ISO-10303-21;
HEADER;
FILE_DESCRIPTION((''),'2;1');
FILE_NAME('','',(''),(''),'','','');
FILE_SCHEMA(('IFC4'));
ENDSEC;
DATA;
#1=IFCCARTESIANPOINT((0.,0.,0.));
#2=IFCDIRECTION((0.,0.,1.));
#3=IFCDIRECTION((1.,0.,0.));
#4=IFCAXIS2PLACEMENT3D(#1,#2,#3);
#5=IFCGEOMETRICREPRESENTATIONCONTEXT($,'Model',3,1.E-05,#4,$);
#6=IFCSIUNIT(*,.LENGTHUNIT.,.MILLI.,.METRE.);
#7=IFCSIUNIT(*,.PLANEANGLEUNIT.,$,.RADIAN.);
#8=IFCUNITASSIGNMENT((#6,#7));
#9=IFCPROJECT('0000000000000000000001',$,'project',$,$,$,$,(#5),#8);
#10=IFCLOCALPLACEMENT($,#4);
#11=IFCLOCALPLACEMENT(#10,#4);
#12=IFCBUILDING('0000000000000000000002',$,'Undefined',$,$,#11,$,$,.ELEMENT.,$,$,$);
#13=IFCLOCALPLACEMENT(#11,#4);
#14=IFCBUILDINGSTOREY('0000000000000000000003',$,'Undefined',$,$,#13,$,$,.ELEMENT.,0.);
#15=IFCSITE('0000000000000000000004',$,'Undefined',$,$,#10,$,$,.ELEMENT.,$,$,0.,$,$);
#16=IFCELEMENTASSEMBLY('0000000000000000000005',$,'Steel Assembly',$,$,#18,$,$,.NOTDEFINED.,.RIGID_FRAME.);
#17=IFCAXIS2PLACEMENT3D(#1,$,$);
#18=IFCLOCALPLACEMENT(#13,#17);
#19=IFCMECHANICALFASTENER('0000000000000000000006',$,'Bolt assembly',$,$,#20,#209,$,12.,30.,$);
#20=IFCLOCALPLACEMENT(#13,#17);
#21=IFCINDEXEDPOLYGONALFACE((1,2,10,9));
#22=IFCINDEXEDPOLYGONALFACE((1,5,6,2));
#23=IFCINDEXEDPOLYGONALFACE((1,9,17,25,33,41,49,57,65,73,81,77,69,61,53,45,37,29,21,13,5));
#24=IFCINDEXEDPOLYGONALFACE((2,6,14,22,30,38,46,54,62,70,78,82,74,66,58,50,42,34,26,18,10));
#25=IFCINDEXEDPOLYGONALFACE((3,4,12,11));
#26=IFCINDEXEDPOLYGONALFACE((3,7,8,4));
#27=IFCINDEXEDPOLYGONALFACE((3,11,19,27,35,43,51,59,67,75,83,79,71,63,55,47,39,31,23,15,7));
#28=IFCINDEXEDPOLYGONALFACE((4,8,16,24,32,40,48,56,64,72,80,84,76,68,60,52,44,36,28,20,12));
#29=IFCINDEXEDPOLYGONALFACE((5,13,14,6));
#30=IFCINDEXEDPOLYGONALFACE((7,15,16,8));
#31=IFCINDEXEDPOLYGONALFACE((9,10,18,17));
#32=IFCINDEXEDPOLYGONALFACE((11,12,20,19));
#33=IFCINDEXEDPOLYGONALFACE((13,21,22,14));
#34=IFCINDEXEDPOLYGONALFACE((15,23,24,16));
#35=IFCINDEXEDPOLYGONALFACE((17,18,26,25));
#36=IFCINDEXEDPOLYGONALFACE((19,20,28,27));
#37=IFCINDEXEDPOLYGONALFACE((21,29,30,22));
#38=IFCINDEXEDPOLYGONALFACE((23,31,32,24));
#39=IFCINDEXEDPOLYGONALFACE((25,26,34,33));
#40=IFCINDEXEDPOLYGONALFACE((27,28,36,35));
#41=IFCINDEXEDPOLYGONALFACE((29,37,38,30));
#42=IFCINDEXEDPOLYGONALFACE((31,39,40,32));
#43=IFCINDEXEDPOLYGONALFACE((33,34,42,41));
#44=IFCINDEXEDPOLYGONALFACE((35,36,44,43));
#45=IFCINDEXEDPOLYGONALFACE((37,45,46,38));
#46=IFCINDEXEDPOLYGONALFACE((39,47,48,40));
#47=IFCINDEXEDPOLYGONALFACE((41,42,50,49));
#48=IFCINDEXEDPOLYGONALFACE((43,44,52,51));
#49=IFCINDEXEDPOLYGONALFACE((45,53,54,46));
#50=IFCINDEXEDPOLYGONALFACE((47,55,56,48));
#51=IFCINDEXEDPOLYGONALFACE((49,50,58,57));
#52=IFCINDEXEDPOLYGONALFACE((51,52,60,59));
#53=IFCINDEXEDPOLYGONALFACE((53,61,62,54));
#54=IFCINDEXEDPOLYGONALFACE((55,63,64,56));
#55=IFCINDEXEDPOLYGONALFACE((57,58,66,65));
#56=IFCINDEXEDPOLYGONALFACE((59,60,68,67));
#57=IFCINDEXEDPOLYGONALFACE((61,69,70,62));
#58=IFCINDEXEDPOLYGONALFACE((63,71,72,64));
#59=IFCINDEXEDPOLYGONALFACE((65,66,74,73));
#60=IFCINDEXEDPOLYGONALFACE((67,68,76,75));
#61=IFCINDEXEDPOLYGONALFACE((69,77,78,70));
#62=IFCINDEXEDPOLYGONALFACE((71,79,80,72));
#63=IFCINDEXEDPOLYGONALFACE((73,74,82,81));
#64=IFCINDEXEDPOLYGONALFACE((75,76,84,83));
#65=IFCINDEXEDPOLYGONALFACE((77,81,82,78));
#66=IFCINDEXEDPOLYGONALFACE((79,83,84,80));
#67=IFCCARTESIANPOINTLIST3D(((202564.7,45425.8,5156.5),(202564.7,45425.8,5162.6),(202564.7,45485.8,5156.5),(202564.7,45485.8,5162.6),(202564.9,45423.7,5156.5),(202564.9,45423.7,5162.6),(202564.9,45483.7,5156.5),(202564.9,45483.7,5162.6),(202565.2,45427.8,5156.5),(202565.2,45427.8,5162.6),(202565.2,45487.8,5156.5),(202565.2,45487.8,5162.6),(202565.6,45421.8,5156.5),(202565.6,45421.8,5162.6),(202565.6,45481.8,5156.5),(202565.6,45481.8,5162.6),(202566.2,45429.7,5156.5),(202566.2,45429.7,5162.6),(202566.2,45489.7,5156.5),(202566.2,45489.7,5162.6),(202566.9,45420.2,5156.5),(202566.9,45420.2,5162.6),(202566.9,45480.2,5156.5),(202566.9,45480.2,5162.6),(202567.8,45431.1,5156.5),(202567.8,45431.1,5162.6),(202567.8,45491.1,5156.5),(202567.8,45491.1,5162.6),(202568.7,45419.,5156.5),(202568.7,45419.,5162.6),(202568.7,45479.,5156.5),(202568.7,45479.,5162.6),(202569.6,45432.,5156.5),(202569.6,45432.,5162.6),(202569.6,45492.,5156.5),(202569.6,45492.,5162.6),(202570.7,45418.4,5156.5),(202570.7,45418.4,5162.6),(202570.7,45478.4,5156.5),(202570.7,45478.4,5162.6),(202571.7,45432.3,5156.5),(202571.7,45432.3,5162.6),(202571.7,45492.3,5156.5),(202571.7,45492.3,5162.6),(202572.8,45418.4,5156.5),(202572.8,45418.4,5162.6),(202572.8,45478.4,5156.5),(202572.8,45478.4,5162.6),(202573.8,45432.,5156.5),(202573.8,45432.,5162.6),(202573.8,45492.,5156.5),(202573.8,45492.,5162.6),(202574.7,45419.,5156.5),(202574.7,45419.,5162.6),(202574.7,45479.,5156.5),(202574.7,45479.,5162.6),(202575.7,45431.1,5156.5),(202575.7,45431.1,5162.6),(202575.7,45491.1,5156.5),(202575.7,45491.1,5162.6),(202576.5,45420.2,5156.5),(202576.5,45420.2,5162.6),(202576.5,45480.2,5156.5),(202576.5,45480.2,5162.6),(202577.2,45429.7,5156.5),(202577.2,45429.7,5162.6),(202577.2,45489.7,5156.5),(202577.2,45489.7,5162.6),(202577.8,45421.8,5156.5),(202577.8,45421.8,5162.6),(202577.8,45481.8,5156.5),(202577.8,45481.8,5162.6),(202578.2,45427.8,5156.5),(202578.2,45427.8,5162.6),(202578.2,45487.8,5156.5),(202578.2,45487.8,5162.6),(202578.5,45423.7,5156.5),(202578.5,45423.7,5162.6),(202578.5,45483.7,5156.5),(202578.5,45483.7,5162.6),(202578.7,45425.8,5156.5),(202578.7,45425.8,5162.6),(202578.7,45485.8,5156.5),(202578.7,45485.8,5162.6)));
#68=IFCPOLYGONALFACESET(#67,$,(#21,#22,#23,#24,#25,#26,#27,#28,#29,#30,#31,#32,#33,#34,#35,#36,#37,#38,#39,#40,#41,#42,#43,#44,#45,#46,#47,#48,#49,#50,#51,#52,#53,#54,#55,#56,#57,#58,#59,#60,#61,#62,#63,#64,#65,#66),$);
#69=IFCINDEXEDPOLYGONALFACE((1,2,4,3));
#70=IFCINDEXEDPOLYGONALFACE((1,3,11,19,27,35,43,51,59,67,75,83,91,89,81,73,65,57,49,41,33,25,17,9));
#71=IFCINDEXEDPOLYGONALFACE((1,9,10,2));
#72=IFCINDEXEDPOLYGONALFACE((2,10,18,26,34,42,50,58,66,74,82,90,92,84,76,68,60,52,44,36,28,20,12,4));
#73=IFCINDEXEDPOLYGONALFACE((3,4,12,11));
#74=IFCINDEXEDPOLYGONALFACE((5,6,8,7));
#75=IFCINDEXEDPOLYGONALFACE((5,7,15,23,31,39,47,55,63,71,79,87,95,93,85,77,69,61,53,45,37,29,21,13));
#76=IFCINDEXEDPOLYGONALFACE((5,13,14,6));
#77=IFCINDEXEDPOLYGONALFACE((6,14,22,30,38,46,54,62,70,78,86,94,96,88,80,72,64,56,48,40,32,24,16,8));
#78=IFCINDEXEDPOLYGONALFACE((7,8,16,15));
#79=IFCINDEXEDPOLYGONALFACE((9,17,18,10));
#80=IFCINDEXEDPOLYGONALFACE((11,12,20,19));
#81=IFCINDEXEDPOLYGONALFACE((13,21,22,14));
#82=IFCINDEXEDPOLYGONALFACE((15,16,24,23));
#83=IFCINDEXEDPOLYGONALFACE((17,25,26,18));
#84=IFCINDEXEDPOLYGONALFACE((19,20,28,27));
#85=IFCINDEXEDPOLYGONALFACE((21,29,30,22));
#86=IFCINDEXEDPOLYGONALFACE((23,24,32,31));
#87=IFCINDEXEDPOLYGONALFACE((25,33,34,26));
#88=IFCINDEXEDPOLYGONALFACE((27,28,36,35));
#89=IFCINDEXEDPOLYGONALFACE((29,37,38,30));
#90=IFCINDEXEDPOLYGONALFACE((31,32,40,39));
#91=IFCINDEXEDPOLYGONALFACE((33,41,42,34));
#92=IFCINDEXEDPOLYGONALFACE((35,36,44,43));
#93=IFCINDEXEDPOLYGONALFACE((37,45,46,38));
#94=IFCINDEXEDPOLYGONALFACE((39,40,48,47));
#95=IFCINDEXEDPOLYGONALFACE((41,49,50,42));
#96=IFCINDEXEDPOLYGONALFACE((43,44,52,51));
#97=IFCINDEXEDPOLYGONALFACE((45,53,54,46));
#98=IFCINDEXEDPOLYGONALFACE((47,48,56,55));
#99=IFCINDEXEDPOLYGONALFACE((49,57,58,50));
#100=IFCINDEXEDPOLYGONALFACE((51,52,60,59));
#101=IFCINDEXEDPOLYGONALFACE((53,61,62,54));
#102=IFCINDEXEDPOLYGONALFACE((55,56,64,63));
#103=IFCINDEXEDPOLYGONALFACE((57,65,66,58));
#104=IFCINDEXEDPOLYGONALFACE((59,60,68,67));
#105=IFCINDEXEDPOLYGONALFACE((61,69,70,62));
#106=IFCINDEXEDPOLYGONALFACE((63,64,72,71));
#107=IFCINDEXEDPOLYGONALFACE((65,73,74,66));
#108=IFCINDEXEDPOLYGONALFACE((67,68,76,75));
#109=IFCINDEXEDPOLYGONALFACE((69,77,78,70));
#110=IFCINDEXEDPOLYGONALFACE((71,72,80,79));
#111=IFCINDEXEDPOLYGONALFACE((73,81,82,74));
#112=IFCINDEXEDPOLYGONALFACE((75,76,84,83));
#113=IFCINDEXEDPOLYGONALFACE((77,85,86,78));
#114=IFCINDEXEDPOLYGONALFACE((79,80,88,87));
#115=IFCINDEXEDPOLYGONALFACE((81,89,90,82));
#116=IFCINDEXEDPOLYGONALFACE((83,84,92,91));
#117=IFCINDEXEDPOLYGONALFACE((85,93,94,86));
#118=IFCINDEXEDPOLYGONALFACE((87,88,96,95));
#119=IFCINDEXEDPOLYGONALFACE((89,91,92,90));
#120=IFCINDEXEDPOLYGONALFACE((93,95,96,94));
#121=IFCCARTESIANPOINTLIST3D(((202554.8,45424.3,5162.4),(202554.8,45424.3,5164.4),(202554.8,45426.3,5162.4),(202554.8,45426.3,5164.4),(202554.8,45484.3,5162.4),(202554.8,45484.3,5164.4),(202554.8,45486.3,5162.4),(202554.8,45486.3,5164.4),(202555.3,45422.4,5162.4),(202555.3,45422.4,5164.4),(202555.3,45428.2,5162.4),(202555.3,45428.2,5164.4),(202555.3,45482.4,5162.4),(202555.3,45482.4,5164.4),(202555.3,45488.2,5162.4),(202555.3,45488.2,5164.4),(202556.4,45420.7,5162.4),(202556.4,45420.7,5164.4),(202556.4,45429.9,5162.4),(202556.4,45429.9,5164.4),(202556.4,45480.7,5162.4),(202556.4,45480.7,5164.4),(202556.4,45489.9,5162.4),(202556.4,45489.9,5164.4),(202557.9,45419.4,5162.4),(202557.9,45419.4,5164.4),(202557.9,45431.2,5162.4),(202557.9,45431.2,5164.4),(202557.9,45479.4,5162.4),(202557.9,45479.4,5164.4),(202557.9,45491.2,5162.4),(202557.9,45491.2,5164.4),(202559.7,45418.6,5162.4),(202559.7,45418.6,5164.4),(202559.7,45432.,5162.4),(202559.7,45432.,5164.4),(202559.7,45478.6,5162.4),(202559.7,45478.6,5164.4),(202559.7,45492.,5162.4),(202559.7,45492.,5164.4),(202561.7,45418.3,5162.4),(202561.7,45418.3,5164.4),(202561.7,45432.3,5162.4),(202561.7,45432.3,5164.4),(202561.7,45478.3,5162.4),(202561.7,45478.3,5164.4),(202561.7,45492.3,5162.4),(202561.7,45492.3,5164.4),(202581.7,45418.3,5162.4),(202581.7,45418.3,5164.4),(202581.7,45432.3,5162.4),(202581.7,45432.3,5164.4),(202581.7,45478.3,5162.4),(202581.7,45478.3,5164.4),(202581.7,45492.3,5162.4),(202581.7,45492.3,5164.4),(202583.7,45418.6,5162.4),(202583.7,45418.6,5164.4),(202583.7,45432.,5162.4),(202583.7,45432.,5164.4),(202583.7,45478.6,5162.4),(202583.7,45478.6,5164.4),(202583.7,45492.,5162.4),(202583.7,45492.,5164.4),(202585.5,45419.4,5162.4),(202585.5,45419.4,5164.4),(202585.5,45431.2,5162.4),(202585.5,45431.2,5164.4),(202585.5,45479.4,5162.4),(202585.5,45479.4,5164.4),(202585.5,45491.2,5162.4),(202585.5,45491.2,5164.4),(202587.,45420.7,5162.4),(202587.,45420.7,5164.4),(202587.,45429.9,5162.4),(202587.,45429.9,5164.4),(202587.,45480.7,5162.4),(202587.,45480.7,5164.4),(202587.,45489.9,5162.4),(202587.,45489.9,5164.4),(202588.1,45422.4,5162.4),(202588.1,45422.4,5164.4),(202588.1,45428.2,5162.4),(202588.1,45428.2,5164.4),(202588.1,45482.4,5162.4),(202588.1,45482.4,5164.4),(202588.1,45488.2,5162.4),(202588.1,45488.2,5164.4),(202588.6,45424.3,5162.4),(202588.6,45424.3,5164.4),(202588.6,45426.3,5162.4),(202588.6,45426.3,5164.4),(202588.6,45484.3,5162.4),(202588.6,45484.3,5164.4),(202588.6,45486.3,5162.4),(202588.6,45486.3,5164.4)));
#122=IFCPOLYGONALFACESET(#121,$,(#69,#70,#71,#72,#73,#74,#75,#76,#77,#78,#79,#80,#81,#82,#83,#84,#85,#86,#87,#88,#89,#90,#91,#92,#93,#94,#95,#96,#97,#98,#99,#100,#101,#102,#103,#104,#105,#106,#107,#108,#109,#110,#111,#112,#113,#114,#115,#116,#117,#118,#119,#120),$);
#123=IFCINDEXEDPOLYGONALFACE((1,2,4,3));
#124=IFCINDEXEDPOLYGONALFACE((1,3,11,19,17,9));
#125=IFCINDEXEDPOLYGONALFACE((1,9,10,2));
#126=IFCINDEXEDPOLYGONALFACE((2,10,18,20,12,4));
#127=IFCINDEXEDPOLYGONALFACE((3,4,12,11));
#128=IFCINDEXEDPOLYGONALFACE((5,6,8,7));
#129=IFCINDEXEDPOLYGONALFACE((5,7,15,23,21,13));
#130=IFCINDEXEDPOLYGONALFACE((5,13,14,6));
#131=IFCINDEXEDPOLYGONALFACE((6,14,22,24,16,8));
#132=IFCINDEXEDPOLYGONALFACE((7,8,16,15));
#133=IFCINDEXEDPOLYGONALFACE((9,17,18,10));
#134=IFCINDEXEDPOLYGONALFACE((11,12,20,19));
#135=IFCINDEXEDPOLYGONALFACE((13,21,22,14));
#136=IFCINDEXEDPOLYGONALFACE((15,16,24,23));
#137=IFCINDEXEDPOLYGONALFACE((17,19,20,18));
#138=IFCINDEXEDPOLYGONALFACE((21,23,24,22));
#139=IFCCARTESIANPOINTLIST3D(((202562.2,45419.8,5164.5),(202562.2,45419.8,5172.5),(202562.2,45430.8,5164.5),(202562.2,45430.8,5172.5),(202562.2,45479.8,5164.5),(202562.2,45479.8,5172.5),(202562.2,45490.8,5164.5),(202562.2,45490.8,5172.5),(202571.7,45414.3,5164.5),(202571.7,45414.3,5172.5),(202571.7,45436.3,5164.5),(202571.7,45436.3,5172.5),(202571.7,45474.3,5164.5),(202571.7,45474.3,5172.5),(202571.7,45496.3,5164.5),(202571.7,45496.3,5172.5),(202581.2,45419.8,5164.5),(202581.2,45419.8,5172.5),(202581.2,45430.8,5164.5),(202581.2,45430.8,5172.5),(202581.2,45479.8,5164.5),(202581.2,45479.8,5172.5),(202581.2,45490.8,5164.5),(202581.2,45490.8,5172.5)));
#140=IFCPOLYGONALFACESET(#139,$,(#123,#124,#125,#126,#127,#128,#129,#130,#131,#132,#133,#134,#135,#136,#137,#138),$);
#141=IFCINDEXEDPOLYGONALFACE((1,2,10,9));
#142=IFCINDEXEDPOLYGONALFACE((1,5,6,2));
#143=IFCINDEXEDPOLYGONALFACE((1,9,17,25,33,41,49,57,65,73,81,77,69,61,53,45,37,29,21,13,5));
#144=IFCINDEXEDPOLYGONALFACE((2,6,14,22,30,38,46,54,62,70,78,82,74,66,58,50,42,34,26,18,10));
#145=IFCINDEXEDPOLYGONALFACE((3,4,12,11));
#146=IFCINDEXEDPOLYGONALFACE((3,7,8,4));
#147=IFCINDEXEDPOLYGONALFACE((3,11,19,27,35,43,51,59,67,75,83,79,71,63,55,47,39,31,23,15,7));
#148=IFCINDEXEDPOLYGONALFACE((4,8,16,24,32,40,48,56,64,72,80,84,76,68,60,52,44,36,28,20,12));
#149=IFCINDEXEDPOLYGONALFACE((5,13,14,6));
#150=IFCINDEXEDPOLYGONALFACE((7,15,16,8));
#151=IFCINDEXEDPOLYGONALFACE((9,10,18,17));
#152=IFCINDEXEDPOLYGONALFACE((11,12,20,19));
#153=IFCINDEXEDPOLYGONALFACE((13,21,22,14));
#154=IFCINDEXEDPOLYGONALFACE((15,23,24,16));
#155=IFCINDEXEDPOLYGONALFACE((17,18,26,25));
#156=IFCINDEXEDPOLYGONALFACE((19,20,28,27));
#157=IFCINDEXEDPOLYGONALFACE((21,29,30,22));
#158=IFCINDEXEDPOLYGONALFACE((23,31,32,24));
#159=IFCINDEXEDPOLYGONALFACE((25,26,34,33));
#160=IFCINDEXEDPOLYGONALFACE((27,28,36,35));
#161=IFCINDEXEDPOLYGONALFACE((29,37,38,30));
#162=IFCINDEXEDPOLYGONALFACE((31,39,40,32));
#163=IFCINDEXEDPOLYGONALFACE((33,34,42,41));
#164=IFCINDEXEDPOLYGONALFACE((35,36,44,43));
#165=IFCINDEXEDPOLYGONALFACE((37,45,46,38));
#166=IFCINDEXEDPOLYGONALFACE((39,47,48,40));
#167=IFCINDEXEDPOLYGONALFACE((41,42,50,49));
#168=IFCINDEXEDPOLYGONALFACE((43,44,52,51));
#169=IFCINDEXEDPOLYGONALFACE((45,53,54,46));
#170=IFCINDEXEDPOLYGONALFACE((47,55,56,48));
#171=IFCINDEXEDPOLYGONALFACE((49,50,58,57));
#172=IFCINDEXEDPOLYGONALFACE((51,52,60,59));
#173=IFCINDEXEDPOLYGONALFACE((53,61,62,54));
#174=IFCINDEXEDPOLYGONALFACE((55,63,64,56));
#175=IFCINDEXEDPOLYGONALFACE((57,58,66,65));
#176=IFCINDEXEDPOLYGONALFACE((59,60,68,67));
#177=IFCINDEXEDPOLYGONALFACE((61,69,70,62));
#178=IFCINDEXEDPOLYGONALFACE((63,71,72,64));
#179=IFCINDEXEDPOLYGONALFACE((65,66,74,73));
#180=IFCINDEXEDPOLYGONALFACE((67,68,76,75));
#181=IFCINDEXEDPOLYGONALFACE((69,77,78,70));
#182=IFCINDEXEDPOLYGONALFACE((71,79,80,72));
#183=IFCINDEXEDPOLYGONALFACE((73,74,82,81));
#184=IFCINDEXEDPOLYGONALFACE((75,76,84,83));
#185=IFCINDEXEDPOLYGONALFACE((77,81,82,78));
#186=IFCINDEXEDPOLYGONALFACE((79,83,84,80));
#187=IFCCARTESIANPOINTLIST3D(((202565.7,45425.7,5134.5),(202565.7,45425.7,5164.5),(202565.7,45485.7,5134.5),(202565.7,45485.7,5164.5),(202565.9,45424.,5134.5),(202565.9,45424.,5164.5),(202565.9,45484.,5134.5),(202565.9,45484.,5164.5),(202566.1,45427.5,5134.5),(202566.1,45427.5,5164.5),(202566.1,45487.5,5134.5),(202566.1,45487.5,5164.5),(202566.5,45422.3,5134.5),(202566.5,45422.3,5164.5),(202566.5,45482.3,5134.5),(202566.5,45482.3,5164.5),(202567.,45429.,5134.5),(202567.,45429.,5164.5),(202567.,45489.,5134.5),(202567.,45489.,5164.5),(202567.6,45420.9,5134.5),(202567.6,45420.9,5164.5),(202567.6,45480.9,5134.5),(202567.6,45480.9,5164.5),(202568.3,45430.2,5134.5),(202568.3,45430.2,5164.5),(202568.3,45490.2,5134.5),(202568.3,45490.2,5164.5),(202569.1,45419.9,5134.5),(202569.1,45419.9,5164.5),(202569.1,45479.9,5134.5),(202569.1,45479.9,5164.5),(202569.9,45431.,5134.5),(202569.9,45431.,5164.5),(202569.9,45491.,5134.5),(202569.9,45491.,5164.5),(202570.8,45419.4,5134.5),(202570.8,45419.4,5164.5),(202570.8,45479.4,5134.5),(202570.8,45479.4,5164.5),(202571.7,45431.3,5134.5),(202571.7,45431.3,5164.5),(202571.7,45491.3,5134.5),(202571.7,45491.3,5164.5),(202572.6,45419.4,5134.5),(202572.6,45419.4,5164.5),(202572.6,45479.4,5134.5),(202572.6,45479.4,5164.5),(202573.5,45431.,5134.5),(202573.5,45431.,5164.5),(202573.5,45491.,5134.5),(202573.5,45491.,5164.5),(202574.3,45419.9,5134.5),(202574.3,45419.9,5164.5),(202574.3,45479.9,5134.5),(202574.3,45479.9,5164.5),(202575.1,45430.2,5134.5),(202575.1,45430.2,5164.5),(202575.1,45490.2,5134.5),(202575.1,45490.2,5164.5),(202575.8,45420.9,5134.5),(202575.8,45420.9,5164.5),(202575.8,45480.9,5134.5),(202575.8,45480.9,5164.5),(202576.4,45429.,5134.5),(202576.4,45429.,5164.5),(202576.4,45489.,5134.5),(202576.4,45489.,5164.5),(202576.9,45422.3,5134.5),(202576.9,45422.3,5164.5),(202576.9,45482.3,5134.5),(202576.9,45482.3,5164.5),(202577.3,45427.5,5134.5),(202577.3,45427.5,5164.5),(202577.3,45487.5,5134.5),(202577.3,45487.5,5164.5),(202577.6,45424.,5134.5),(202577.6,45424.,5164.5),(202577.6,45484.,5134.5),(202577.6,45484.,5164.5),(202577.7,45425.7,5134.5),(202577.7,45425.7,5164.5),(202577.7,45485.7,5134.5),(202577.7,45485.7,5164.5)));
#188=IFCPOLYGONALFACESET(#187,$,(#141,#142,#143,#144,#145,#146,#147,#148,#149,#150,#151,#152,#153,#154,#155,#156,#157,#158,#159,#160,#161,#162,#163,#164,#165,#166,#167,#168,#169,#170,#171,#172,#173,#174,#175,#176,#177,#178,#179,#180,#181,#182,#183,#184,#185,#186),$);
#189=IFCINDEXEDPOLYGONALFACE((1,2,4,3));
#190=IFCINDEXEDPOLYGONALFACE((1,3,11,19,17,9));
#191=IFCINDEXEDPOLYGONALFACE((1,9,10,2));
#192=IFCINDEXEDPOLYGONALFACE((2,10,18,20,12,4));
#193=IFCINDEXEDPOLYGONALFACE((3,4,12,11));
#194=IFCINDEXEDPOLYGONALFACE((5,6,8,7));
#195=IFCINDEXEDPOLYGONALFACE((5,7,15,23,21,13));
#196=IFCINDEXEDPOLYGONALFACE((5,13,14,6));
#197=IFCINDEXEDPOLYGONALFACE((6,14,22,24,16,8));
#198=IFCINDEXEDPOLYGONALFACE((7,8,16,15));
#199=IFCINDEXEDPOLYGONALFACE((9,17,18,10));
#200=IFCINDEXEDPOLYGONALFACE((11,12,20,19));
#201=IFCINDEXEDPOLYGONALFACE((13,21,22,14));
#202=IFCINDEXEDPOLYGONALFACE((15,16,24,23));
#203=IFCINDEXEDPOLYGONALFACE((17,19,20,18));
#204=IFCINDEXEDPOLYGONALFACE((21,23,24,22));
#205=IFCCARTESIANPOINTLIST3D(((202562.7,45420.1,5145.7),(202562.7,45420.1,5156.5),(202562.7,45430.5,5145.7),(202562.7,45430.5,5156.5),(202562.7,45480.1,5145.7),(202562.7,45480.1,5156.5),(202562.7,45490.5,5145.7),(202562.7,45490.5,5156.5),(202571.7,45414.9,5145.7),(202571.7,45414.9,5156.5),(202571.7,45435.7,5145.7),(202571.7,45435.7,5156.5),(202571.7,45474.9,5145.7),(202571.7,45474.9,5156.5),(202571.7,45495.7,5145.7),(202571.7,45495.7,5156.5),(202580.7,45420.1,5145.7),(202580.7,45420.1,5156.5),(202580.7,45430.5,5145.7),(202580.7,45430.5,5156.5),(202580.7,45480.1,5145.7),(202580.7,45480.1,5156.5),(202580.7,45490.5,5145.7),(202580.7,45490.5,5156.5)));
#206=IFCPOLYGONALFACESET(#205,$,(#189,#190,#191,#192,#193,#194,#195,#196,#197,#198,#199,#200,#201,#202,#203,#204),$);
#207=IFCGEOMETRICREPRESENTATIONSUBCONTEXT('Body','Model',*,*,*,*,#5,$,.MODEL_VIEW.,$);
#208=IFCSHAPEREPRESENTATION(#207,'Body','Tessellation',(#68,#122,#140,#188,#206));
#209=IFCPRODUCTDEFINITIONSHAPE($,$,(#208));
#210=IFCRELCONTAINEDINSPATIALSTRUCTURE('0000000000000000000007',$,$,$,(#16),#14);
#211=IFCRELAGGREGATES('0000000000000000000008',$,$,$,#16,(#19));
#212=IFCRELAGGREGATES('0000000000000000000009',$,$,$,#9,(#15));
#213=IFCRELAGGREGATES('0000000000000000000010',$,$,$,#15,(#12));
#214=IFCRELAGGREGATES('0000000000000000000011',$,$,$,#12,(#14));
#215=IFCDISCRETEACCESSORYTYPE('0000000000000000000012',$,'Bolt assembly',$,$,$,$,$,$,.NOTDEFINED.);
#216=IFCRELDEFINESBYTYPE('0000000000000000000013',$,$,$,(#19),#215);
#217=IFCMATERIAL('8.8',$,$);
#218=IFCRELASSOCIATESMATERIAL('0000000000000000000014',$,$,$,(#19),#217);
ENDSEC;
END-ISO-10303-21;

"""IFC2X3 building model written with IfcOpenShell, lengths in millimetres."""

from ifc_helpers import new_model, si_unit, frame, frame_2d, origin_with_axes, origin_2d_with_axis, place, context, subcontext, project, spatial, polyline, circle_curve, parameter, trimmed, segment, composite_curve, circle, outline, extrude, source, transform, mapped, material, type_object, element, aggregate, save


model = new_model("IFC2X3")

# Units and contexts
model_context = context("Model", 3, precision=1e-05, world=origin_with_axes())
body_context = subcontext(model_context, "Body", "Model", "MODEL_VIEW")
ifc_project = project(units=[si_unit("LENGTHUNIT", "METRE", prefix="MILLI"), si_unit("PLANEANGLEUNIT", "RADIAN")], contexts=[model_context])

# Site, building, storey
site_placement = place(None, origin_with_axes())
site = spatial("IfcSite", under=ifc_project, at=site_placement, Name="Undefined", CompositionType="ELEMENT", RefElevation=0.0)
building_placement = place(site_placement, origin_with_axes())
building = spatial("IfcBuilding", under=site, at=building_placement, Name="Undefined", CompositionType="ELEMENT")
storey_placement = place(building_placement, origin_with_axes())
storey = spatial("IfcBuildingStorey", under=building, at=storey_placement, Name="Undefined", CompositionType="ELEMENT", Elevation=0.0)

# Element assembly
assembly_1_placement = place(storey_placement, origin_with_axes())
assembly_1 = element("IfcElementAssembly", 1, at=assembly_1_placement, inside=storey, Name="Steel Assembly", AssemblyPlace="NOTDEFINED", PredefinedType="RIGID_FRAME")

# Shared definitions
discrete_accessory_type_1 = type_object("IfcDiscreteAccessoryType", Name="Bolt assembly")
ifc_material_1 = material(Name="8.8")

# Mechanical fastener
shared_shape_1 = source(origin_with_axes(), body_context, "Body", "SweptSolid", [
    extrude(circle(Radius=7.0, at=origin_2d_with_axis()), frame((0.0, -3.1, 0.0), z_axis=(0.0, 1.0, 0.0), x_axis=(1.0, 0.0, 0.0)), (0.0, 0.0, 1.0), 6.1),
    extrude(outline(composite_curve([segment(polyline([(7.0, 10.0), (7.0, -10.0)]), True, "CONTINUOUS"), segment(trimmed(circle_curve(frame_2d((0.0, -10.0), x_axis=(1.0, 0.0)), 7.0), [parameter(0.0)], [parameter(3.1416)], False, "PARAMETER"), True, "CONTINUOUS"), segment(polyline([(-7.0, -10.0), (-7.0, 10.0)]), True, "CONTINUOUS"), segment(trimmed(circle_curve(frame_2d((0.0, 10.0), x_axis=(-1.0, 0.0)), 7.0), [parameter(0.0)], [parameter(3.1416)], False, "PARAMETER"), True, "DISCONTINUOUS")], self_intersect=False)), frame((0.0, -4.9, 0.0), z_axis=(0.0, 1.0, 0.0), x_axis=(1.0, 0.0, 0.0)), (0.0, 0.0, 1.0), 2.0),
    extrude(outline(polyline([(11.0, 0.0), (5.5, 9.5), (-5.5, 9.5), (-11.0, 0.0), (-5.5, -9.5), (5.5, -9.5), (11.0, 0.0)])), frame((0.0, -13.0, 0.0), z_axis=(0.0, 1.0, 0.0), x_axis=(1.0, 0.0, 0.0)), (0.0, 0.0, 1.0), 8.0),
    extrude(circle(Radius=6.0, at=origin_2d_with_axis()), frame((0.0, -5.0, 0.0), z_axis=(0.0, 1.0, 0.0), x_axis=(1.0, 0.0, 0.0)), (0.0, 0.0, 1.0), 30.0),
    extrude(outline(polyline([(10.4, 0.0), (5.2, 9.0), (-5.2, 9.0), (-10.4, 0.0), (-5.2, -9.0), (5.2, -9.0), (10.4, 0.0)])), frame((0.0, 3.0, 0.0), z_axis=(0.0, 1.0, 0.0), x_axis=(1.0, 0.0, 0.0)), (0.0, 0.0, 1.0), 10.8),
])
mechanical_fastener_1_placement = place(assembly_1_placement, frame((202616.7, 45380.3, 5159.5), z_axis=(-1.0, 0.0, 0.0), x_axis=(0.0, 1.0, 0.0)))
mechanical_fastener_1 = element("IfcMechanicalFastener", 2, at=mechanical_fastener_1_placement, type_object=discrete_accessory_type_1, material=ifc_material_1, Name="Bolt assembly", NominalDiameter=12.0, NominalLength=30.0, context=body_context, shape_type="MappedRepresentation", body=[
    mapped(shared_shape_1, transform((45.0, 0.0, 45.0))),
    mapped(shared_shape_1, transform((105.0, 0.0, 45.0))),
])
aggregate(assembly_1, [mechanical_fastener_1])

save(model, "model.ifc")
